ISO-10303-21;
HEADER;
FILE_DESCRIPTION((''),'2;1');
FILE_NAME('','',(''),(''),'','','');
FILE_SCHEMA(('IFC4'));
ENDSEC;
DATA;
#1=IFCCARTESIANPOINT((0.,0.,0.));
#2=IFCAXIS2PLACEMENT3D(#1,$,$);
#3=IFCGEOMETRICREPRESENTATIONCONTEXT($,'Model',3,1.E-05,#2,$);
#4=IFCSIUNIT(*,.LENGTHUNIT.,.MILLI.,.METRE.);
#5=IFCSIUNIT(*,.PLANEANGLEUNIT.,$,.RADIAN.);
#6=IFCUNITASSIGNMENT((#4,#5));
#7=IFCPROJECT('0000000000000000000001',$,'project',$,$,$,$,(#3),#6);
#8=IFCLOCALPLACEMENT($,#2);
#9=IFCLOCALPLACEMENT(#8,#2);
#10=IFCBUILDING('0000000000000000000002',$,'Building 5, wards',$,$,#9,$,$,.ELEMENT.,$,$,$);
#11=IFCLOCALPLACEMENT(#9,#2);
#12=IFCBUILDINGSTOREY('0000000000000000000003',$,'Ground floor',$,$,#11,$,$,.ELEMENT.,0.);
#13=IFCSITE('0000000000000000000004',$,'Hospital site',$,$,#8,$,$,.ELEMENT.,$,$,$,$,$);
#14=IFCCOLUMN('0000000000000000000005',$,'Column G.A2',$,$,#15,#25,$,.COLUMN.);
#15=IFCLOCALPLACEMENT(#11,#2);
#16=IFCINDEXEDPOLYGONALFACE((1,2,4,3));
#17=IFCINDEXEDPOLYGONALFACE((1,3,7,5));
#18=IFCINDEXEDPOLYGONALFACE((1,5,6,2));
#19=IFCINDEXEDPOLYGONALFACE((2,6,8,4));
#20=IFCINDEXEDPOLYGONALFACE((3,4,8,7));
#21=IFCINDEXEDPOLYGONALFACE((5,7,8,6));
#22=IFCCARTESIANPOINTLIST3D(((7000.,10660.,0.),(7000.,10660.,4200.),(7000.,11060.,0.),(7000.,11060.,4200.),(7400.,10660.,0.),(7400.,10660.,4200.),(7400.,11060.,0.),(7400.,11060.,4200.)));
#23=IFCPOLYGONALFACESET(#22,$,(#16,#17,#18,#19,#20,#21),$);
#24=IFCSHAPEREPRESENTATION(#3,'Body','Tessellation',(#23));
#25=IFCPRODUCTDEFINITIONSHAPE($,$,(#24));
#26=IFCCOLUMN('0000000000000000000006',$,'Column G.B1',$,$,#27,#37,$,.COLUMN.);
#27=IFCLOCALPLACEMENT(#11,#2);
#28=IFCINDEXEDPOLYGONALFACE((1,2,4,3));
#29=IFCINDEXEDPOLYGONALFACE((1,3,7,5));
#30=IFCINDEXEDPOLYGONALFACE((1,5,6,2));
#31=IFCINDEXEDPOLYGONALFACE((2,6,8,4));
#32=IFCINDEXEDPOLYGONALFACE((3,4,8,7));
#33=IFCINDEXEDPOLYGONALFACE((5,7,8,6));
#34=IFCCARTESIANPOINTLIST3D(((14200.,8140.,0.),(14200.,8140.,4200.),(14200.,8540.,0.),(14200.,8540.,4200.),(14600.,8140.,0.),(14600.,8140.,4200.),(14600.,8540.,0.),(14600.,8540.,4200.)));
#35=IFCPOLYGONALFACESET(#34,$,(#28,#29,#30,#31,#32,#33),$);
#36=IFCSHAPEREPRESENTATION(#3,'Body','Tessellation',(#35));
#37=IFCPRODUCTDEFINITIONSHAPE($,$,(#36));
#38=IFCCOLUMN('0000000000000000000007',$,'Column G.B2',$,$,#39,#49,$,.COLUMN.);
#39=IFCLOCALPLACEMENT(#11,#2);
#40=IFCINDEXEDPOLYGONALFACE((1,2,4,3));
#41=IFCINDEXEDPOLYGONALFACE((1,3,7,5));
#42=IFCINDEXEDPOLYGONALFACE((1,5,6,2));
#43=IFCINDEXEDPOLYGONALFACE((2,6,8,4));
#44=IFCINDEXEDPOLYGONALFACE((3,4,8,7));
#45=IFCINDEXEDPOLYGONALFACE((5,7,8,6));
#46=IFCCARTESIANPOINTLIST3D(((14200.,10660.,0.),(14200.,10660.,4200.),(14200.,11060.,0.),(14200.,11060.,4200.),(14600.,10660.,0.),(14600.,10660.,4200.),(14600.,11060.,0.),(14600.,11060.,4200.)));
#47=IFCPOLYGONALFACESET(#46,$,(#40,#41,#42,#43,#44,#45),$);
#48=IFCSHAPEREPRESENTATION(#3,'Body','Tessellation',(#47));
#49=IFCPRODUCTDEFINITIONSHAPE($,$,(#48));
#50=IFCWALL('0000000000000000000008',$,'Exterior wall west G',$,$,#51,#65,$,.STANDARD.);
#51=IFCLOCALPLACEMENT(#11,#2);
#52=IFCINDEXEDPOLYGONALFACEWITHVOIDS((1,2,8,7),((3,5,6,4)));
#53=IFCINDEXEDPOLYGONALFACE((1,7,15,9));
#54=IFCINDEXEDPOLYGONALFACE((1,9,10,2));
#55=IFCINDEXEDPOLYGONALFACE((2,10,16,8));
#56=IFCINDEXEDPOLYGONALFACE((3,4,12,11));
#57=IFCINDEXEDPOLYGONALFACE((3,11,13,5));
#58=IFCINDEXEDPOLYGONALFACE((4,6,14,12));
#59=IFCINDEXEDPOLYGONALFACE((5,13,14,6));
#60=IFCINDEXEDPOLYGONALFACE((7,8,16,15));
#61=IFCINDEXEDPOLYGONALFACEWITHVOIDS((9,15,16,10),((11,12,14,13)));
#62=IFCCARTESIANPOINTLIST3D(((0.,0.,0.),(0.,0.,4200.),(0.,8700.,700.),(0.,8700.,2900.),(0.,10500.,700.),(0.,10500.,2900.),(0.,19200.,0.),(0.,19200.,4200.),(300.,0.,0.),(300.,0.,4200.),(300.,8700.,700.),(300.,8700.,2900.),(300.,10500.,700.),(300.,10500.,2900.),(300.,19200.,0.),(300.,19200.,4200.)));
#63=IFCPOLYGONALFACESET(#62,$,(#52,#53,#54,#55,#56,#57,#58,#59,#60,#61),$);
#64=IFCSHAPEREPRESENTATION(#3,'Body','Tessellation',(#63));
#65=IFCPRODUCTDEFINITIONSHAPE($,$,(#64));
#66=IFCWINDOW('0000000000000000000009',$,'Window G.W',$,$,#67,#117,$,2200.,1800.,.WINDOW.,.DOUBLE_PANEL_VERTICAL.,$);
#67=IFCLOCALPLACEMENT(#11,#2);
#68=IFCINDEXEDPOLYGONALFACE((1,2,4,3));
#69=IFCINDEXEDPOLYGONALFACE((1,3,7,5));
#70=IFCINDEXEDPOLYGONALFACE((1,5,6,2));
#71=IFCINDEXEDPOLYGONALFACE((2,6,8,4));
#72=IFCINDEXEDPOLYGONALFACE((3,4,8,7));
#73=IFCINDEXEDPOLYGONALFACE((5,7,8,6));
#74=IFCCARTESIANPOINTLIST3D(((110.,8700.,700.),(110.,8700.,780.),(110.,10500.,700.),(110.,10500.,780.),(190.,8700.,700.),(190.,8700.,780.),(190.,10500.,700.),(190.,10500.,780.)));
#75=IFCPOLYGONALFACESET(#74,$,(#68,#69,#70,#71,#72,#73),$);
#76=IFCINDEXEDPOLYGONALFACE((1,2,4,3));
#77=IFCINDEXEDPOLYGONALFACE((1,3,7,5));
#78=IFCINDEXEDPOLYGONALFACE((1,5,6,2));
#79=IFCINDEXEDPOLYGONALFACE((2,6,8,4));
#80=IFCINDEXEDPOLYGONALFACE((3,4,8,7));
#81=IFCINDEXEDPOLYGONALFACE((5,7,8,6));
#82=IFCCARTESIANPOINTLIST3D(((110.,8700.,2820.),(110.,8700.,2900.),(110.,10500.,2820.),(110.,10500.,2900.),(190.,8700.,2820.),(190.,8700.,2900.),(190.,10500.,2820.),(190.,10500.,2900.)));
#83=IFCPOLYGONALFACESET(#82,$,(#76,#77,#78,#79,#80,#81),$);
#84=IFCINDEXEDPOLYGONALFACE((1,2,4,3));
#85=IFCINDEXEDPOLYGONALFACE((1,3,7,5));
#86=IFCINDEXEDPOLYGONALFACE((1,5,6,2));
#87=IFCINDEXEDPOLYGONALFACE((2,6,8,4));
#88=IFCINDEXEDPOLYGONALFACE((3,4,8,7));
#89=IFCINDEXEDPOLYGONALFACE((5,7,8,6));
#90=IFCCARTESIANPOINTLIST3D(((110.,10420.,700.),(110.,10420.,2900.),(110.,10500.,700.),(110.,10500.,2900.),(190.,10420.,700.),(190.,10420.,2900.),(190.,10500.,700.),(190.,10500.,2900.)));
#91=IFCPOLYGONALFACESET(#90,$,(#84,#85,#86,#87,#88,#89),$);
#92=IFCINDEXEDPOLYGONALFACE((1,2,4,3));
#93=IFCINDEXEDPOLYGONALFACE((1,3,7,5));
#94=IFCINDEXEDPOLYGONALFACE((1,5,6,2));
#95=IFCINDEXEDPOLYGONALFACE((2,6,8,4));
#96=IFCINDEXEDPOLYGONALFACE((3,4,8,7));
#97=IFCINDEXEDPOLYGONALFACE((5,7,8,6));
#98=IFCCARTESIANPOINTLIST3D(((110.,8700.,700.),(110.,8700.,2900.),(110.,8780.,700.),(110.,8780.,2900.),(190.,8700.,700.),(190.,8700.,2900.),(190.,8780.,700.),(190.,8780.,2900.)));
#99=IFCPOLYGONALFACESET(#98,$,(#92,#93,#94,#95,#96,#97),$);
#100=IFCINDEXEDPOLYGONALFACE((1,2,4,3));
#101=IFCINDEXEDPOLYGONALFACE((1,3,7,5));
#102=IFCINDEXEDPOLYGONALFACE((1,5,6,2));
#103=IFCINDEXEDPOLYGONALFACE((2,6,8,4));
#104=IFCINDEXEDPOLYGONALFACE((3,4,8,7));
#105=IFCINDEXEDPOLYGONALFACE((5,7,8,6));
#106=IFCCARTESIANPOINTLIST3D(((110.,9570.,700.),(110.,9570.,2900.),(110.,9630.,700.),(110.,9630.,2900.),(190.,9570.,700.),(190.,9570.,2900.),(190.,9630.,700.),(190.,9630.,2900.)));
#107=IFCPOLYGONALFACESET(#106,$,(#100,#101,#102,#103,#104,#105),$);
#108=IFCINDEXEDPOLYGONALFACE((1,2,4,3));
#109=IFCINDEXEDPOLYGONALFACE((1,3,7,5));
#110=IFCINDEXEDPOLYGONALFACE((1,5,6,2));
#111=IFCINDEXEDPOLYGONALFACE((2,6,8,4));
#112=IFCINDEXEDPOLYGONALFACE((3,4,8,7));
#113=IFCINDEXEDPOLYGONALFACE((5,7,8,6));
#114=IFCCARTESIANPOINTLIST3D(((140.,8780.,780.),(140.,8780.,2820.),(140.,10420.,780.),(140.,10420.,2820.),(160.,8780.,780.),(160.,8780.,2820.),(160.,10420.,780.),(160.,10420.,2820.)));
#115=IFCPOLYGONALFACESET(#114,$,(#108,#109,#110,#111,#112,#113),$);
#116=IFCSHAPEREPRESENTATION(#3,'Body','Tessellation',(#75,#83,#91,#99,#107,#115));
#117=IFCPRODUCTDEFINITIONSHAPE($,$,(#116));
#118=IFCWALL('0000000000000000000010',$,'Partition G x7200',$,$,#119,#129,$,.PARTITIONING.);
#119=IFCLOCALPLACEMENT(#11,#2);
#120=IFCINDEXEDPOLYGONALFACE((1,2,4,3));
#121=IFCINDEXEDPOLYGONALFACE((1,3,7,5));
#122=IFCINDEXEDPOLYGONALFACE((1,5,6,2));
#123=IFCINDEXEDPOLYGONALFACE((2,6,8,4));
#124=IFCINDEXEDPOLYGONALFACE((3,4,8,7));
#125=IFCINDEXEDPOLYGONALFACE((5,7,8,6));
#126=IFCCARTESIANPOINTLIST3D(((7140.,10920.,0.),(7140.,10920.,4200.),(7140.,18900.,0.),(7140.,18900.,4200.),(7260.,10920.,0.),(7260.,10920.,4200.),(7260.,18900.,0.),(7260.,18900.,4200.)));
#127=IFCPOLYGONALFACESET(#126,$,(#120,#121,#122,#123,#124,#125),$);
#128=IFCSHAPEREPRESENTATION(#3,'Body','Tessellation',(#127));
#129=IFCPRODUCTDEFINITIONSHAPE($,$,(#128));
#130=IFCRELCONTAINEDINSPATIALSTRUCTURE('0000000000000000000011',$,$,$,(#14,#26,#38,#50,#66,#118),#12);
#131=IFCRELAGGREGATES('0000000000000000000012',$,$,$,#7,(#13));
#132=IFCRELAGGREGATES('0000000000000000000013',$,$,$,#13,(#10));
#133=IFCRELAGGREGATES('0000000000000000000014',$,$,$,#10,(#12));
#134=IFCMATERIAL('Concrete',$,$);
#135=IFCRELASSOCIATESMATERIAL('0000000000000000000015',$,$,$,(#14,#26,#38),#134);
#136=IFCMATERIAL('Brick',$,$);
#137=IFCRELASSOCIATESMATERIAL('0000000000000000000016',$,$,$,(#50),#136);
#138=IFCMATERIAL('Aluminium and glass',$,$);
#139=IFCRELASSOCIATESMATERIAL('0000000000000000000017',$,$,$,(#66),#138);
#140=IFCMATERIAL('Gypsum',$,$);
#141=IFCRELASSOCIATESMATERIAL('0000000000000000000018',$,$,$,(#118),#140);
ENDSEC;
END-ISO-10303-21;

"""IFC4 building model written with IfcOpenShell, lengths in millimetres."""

from ifc_helpers import new_model, si_unit, frame, frame_2d, origin, origin_2d, place, context, project, spatial, rectangle, extrude, material, element, fill, save


model = new_model("IFC4")

# Units and contexts
model_context = context("Model", 3, precision=1e-05, world=origin())
ifc_project = project(units=[si_unit("LENGTHUNIT", "METRE", prefix="MILLI"), si_unit("PLANEANGLEUNIT", "RADIAN")], contexts=[model_context])

# Site, building, storey
site_placement = place(None, origin())
site = spatial("IfcSite", under=ifc_project, at=site_placement, Name="Hospital site", CompositionType="ELEMENT")
building_placement = place(site_placement, origin())
building = spatial("IfcBuilding", under=site, at=building_placement, Name="Building 5, wards", CompositionType="ELEMENT")
storey_placement = place(building_placement, origin())
storey = spatial("IfcBuildingStorey", under=building, at=storey_placement, Name="Ground floor", CompositionType="ELEMENT", Elevation=0.0)

# Columns
ifc_material_1 = material(Name="Concrete")
for number, where, name in (
    (1, (7200.0, 10860.0, 0.0), "Column G.A2"),
    (2, (14400.0, 8340.0, 0.0), "Column G.B1"),
    (3, (14400.0, 10860.0, 0.0), "Column G.B2"),
):
    element("IfcColumn", number, at=place(storey_placement, frame(where)), inside=storey, material=ifc_material_1, Name=name, PredefinedType="COLUMN", context=model_context, shape_type="SweptSolid", body=[
        extrude(rectangle(XDim=400.0, YDim=400.0, at=origin_2d()), origin(), (0.0, 0.0, 1.0), 4200.0),
    ])

# Wall, opening, window
ifc_material_2 = material(Name="Brick")
wall_1_placement = place(storey_placement, frame((0.0, 19200.0, 0.0), x_axis=(0.0, -1.0, 0.0)))
wall_1 = element("IfcWall", 4, at=wall_1_placement, inside=storey, material=ifc_material_2, Name="Exterior wall west G", PredefinedType="STANDARD", context=model_context, shape_type="SweptSolid", body=[
    extrude(rectangle(XDim=19200.0, YDim=300.0, at=frame_2d((9600.0, 150.0))), origin(), (0.0, 0.0, 1.0), 4200.0),
])
opening_placement = place(wall_1_placement, frame((8700.0, -50.0, 700.0)))
opening = element("IfcOpeningElement", 5, at=opening_placement, cuts=wall_1, PredefinedType="OPENING", context=model_context, shape_type="SweptSolid", body=[
    extrude(rectangle(XDim=1800.0, YDim=400.0, at=frame_2d((900.0, 200.0))), origin(), (0.0, 0.0, 1.0), 2200.0),
])
ifc_material_3 = material(Name="Aluminium and glass")
window_placement = place(opening_placement, frame((0.0, 160.0, 0.0)))
window = element("IfcWindow", 6, at=window_placement, inside=storey, material=ifc_material_3, Name="Window G.W", OverallHeight=2200.0, OverallWidth=1800.0, PartitioningType="DOUBLE_PANEL_VERTICAL", PredefinedType="WINDOW", context=model_context, shape_type="SweptSolid", body=[
    extrude(rectangle(XDim=1800.0, YDim=80.0, at=frame_2d((900.0, 40.0))), origin(), (0.0, 0.0, 1.0), 80.0),
    extrude(rectangle(XDim=1800.0, YDim=80.0, at=frame_2d((900.0, 40.0))), frame((0.0, 0.0, 2120.0)), (0.0, 0.0, 1.0), 80.0),
    extrude(rectangle(XDim=80.0, YDim=80.0, at=frame_2d((40.0, 40.0))), origin(), (0.0, 0.0, 1.0), 2200.0),
    extrude(rectangle(XDim=80.0, YDim=80.0, at=frame_2d((1760.0, 40.0))), origin(), (0.0, 0.0, 1.0), 2200.0),
    extrude(rectangle(XDim=60.0, YDim=80.0, at=frame_2d((900.0, 40.0))), origin(), (0.0, 0.0, 1.0), 2200.0),
    extrude(rectangle(XDim=1640.0, YDim=20.0, at=frame_2d((900.0, 40.0))), frame((0.0, 0.0, 80.0)), (0.0, 0.0, 1.0), 2040.0),
])
fill(opening, window)

# Wall
ifc_material_4 = material(Name="Gypsum")
wall_2_placement = place(storey_placement, frame((7260.0, 10920.0, 0.0), x_axis=(0.0, 1.0, 0.0)))
element("IfcWall", 7, at=wall_2_placement, inside=storey, material=ifc_material_4, Name="Partition G x7200", PredefinedType="PARTITIONING", context=model_context, shape_type="SweptSolid", body=[
    extrude(rectangle(XDim=7980.0, YDim=120.0, at=frame_2d((3990.0, 60.0))), origin(), (0.0, 0.0, 1.0), 4200.0),
])

save(model, "model.ifc")
